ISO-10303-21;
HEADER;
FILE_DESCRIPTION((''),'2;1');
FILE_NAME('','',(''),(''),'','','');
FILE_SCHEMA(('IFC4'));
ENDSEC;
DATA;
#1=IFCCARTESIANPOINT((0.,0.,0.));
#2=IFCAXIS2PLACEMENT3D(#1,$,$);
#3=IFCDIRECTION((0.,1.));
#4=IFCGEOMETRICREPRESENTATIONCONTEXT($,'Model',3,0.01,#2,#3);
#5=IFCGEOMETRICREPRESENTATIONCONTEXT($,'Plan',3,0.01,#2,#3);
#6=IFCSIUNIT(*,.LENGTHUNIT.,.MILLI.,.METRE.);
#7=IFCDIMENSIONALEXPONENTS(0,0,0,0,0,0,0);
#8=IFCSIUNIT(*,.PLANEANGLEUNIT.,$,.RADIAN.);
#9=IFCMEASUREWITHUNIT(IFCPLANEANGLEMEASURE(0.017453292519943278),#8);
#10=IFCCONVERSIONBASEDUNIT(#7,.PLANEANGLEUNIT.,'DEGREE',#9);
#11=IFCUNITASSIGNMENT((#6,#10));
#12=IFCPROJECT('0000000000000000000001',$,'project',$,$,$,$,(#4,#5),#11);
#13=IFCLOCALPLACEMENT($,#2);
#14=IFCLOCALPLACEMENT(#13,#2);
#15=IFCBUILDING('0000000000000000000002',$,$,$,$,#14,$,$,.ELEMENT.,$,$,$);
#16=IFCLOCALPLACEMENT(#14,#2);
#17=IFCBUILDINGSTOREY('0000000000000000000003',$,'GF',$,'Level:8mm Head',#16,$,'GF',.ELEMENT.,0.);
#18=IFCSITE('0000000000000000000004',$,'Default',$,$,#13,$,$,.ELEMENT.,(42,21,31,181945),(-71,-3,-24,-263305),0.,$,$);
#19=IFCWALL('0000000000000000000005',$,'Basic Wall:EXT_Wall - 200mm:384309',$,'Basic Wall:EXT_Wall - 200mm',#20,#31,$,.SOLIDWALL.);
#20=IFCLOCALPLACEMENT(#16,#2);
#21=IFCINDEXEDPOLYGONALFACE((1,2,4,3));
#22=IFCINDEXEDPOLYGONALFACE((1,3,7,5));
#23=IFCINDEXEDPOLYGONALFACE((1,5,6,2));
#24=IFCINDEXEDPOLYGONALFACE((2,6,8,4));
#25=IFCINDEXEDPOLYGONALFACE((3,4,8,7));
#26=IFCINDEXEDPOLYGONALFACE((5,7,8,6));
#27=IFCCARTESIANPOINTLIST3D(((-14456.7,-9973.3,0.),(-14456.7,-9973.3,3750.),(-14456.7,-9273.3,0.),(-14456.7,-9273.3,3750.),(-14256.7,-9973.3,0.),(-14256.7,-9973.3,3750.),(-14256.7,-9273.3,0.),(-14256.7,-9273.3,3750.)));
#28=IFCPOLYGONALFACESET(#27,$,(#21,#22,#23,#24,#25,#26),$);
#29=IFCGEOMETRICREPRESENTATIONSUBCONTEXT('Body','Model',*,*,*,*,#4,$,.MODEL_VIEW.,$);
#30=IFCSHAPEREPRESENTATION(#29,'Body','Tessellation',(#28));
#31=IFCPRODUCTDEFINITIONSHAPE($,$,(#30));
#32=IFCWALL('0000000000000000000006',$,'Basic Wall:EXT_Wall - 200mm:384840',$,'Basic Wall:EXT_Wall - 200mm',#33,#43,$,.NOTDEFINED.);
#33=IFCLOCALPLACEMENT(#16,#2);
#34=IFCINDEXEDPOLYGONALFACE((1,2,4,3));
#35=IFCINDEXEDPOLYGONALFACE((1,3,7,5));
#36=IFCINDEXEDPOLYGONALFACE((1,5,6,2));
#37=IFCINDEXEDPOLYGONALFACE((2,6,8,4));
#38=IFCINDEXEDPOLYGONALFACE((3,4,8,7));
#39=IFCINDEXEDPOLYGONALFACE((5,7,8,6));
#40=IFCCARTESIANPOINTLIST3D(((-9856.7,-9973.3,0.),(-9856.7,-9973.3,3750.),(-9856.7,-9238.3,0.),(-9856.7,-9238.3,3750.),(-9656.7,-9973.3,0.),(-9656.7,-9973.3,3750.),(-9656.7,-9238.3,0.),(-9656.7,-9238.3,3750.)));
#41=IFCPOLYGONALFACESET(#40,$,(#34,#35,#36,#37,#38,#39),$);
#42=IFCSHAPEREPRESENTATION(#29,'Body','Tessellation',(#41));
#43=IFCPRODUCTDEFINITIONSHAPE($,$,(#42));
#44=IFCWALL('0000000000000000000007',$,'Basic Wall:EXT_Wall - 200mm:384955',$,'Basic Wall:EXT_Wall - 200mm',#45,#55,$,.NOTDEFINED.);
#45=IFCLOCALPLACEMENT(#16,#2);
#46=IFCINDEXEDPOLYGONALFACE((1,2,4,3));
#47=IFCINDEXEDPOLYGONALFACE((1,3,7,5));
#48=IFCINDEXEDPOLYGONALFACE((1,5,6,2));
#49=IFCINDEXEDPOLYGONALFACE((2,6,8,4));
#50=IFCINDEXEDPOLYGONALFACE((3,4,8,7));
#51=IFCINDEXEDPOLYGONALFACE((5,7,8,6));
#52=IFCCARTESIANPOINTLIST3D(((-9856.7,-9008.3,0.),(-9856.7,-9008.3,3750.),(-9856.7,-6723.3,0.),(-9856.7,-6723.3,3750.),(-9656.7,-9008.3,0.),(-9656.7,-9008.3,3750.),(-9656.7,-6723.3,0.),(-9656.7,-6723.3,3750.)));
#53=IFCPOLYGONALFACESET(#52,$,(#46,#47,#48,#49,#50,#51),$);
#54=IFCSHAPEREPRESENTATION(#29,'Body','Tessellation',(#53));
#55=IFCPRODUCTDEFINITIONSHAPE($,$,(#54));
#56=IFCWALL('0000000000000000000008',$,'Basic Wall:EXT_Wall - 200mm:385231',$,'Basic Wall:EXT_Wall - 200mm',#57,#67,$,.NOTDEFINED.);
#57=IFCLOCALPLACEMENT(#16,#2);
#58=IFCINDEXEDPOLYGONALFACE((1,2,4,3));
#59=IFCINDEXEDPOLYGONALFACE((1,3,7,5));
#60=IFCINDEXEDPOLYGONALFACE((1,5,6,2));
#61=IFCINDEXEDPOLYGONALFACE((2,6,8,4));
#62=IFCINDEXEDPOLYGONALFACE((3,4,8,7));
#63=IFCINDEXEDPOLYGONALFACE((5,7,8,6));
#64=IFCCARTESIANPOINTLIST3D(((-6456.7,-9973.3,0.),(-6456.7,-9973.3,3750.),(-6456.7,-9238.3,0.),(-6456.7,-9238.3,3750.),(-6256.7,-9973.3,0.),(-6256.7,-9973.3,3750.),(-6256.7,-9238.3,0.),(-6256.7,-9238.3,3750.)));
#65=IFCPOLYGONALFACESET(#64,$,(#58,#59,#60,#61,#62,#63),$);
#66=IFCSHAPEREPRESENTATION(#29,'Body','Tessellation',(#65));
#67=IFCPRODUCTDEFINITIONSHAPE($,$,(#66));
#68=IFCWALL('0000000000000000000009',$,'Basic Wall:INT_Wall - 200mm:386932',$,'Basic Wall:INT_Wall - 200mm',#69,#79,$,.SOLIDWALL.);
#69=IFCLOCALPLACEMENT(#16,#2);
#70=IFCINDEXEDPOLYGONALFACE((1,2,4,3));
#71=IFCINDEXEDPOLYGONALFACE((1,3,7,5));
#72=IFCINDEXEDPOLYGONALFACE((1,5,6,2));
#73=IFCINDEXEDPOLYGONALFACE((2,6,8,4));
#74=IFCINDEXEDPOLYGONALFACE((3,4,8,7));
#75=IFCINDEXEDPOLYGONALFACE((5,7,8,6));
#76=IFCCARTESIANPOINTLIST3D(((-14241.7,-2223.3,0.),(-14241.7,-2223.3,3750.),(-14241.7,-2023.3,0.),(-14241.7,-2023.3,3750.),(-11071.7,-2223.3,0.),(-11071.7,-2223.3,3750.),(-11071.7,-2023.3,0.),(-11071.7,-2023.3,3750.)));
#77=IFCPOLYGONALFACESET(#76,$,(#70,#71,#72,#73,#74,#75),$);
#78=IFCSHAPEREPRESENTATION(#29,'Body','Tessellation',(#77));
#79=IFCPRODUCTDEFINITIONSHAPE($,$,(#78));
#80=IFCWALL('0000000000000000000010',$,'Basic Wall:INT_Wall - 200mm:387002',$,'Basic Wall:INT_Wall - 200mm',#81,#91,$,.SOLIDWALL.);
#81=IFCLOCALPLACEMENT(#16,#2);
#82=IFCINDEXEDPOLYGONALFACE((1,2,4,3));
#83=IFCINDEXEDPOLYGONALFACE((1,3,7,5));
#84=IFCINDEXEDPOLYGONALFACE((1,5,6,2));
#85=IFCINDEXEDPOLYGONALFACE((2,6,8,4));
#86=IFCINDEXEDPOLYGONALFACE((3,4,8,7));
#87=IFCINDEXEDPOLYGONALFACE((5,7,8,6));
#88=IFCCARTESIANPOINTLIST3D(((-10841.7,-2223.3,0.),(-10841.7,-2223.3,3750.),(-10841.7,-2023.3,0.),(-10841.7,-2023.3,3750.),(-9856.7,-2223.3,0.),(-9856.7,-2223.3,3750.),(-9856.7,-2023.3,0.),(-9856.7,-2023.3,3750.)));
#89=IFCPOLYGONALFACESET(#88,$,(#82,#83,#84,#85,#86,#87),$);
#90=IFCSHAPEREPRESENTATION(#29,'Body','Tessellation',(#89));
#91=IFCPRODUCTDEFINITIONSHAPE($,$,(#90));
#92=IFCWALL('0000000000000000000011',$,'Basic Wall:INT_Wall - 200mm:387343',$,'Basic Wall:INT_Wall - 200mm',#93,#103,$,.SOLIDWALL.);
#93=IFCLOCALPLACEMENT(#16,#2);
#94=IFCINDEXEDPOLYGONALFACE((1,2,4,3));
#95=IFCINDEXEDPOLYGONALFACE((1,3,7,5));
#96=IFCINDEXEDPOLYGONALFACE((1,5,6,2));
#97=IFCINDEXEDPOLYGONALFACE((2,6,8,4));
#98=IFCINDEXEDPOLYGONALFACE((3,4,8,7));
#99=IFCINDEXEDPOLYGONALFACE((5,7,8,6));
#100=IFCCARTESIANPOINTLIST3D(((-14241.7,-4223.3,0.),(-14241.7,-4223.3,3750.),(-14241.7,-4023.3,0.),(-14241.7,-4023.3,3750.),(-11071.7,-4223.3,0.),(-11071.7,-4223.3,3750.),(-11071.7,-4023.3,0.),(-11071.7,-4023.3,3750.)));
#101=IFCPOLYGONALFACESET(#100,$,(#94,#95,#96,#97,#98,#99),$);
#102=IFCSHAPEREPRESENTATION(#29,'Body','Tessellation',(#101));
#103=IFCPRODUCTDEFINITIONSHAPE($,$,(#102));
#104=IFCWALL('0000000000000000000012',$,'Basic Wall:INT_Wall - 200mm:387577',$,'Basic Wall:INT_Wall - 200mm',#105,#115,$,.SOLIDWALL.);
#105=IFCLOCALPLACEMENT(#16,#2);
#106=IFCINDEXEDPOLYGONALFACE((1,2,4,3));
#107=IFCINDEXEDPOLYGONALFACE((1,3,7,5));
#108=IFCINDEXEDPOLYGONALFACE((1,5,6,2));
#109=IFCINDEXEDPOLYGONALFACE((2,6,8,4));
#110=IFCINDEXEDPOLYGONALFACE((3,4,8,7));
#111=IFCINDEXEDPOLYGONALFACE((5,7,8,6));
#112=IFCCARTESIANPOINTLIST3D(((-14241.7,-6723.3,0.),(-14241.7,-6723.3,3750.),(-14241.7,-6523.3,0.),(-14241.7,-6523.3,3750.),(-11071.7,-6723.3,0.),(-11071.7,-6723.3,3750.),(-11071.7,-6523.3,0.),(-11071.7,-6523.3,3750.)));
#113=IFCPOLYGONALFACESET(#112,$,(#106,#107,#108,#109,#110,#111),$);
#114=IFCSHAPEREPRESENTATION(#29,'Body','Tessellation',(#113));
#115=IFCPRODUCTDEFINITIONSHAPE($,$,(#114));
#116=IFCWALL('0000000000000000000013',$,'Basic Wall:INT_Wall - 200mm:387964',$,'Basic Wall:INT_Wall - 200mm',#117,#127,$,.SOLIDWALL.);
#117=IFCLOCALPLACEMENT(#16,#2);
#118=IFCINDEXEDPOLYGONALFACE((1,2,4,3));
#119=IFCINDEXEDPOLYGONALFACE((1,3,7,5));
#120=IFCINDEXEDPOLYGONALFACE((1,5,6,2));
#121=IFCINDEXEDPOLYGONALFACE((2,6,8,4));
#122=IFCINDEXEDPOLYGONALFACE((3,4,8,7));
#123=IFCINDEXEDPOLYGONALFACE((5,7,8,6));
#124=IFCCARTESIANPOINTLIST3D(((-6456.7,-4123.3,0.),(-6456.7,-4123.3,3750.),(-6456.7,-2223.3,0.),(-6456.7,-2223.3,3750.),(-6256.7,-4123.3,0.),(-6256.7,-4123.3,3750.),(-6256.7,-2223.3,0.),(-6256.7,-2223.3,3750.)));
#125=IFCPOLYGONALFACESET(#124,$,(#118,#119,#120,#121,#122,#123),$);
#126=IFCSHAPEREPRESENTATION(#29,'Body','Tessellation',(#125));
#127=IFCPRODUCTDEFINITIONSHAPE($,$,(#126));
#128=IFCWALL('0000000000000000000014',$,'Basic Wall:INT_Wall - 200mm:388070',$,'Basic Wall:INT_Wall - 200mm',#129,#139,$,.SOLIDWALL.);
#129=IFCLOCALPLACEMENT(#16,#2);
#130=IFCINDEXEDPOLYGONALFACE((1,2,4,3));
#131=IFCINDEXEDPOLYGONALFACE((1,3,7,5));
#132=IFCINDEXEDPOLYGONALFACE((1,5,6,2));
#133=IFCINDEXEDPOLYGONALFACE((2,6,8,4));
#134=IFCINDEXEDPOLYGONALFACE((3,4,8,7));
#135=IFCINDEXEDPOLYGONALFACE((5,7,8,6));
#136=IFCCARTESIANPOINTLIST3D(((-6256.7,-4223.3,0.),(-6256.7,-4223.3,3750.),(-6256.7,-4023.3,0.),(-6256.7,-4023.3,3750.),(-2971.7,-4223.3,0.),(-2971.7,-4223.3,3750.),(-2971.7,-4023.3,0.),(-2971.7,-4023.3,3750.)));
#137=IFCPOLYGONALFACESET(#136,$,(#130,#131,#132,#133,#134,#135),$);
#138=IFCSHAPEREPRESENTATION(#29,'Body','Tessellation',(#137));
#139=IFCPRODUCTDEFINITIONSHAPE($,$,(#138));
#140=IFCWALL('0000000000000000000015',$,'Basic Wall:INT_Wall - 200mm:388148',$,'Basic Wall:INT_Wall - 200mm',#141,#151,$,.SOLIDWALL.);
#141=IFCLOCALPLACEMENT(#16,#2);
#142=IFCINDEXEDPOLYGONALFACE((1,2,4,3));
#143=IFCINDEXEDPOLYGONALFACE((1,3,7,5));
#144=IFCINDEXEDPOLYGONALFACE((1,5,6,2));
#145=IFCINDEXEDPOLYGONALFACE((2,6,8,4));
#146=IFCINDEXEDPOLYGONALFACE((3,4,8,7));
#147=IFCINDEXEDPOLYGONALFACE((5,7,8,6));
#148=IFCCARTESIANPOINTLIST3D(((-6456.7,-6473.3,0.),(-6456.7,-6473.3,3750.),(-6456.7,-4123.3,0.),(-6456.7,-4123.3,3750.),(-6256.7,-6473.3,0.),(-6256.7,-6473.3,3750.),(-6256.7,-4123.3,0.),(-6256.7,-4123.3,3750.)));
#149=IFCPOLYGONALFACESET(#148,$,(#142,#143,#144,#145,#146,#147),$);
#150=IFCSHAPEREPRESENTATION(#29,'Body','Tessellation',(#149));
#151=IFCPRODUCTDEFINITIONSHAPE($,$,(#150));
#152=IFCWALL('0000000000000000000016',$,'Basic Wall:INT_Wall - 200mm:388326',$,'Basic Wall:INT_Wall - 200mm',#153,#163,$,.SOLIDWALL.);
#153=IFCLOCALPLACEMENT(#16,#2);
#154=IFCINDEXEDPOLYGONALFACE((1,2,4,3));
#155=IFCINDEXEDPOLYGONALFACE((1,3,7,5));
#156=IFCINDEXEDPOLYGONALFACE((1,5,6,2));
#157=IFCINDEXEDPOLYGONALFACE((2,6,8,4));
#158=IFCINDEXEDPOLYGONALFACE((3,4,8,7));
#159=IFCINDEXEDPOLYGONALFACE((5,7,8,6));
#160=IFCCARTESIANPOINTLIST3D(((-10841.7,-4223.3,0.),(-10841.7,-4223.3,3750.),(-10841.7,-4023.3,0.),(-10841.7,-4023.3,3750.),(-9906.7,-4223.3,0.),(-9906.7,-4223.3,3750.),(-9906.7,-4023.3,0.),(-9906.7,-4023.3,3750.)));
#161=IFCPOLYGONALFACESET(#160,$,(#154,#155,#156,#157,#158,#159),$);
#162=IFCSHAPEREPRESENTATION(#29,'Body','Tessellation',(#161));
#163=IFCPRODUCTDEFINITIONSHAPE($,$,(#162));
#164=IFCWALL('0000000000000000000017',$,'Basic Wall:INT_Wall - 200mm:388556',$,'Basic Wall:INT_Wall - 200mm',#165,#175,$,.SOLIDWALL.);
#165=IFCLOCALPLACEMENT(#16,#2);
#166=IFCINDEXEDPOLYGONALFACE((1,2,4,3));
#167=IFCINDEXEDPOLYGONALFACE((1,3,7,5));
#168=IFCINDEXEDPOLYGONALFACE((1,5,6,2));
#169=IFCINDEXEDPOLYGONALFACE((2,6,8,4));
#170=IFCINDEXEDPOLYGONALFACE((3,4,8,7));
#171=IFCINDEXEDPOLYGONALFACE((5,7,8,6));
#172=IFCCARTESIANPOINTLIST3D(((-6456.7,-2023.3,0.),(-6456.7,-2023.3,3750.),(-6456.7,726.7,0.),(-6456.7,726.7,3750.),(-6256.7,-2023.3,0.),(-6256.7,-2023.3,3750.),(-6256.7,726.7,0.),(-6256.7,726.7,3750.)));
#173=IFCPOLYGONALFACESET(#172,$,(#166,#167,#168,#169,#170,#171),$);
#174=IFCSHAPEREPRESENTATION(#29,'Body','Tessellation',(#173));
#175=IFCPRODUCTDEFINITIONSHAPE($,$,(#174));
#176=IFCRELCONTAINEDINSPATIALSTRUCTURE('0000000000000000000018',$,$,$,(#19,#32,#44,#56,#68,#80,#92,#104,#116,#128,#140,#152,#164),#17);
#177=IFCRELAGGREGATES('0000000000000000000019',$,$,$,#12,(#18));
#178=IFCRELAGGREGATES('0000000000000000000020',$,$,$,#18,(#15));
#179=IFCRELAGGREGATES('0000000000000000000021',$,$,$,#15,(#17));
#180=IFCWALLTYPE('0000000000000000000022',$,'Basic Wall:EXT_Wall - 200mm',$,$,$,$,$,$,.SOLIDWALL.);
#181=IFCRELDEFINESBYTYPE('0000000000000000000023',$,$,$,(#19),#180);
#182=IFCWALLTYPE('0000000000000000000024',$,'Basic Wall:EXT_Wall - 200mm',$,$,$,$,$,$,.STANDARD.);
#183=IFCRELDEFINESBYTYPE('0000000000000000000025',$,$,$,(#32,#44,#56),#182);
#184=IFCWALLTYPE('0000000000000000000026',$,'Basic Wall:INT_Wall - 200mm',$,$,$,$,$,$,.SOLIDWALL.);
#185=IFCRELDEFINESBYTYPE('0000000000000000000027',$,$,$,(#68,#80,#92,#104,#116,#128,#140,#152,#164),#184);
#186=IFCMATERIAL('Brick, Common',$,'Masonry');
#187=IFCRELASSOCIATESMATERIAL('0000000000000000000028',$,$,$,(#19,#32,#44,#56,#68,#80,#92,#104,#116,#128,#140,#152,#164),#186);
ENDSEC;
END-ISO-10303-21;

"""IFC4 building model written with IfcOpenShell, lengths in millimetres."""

from ifc_helpers import new_model, entity, si_unit, converted_unit, direction, frame, origin, place, context, subcontext, project, spatial, indexed_curve, outline, extrude, material, type_object, element, save


model = new_model("IFC4")

# Units and contexts
model_context = context("Model", 3, precision=0.01, world=origin(), true_north=direction((0.0, 1.0)))
plan_context = context("Plan", 3, precision=0.01, world=origin(), true_north=direction((0.0, 1.0)))
body_context = subcontext(model_context, "Body", "Model", "MODEL_VIEW")
ifc_project = project(units=[si_unit("LENGTHUNIT", "METRE", prefix="MILLI"), converted_unit("PLANEANGLEUNIT", "DEGREE", entity("IfcPlaneAngleMeasure", 0.017453292519943278), si_unit("PLANEANGLEUNIT", "RADIAN"), dimensions=[0, 0, 0, 0, 0, 0, 0])], contexts=[model_context, plan_context])

# Site, building, storey
site_placement = place(None, origin())
site = spatial("IfcSite", under=ifc_project, at=site_placement, Name="Default", CompositionType="ELEMENT", RefLatitude=(42, 21, 31, 181945), RefLongitude=(-71, -3, -24, -263305), RefElevation=0.0)
building_placement = place(site_placement, origin())
building = spatial("IfcBuilding", under=site, at=building_placement, CompositionType="ELEMENT")
storey_placement = place(building_placement, origin())
storey = spatial("IfcBuildingStorey", under=building, at=storey_placement, Name="GF", ObjectType="Level:8mm Head", LongName="GF", CompositionType="ELEMENT", Elevation=0.0)

# Walls
ifc_material_1 = material(Name="Brick, Common", Category="Masonry")
wall_type_1 = type_object("IfcWallType", Name="Basic Wall:EXT_Wall - 200mm", PredefinedType="SOLIDWALL")
wall_1_placement = place(storey_placement, frame((-14356.7, -9973.3, 0.0), z_axis=(0.0, 0.0, 1.0), x_axis=(0.0, 1.0, 0.0)))
element("IfcWall", 1, at=wall_1_placement, inside=storey, type_object=wall_type_1, material=ifc_material_1, Name="Basic Wall:EXT_Wall - 200mm:384309", ObjectType="Basic Wall:EXT_Wall - 200mm", PredefinedType="SOLIDWALL", context=body_context, shape_type="SweptSolid", body=[
    extrude(outline(indexed_curve([(700.0, 100.0), (0.0, 100.0), (0.0, -100.0), (700.0, -100.0), (700.0, 100.0)], self_intersect=False)), origin(), (0.0, 0.0, 1.0), 3750.0),
])
wall_type_2 = type_object("IfcWallType", Name="Basic Wall:EXT_Wall - 200mm", PredefinedType="STANDARD")
wall_2_placement = place(storey_placement, frame((-9756.7, -9973.3, 0.0), z_axis=(0.0, 0.0, 1.0), x_axis=(0.0, 1.0, 0.0)))
element("IfcWall", 2, at=wall_2_placement, inside=storey, type_object=wall_type_2, material=ifc_material_1, Name="Basic Wall:EXT_Wall - 200mm:384840", ObjectType="Basic Wall:EXT_Wall - 200mm", PredefinedType="NOTDEFINED", context=body_context, shape_type="SweptSolid", body=[
    extrude(outline(indexed_curve([(735.0, 100.0), (0.0, 100.0), (0.0, -100.0), (735.0, -100.0), (735.0, 100.0)], self_intersect=False)), origin(), (0.0, 0.0, 1.0), 3750.0),
])
wall_3_placement = place(storey_placement, frame((-9756.7, -9008.3, 0.0), z_axis=(0.0, 0.0, 1.0), x_axis=(0.0, 1.0, 0.0)))
element("IfcWall", 3, at=wall_3_placement, inside=storey, type_object=wall_type_2, material=ifc_material_1, Name="Basic Wall:EXT_Wall - 200mm:384955", ObjectType="Basic Wall:EXT_Wall - 200mm", PredefinedType="NOTDEFINED", context=body_context, shape_type="SweptSolid", body=[
    extrude(outline(indexed_curve([(2285.0, 100.0), (0.0, 100.0), (0.0, -100.0), (2285.0, -100.0), (2285.0, 100.0)], self_intersect=False)), origin(), (0.0, 0.0, 1.0), 3750.0),
])
wall_4_placement = place(storey_placement, frame((-6356.7, -9238.3, 0.0), z_axis=(0.0, 0.0, 1.0), x_axis=(0.0, -1.0, 0.0)))
element("IfcWall", 4, at=wall_4_placement, inside=storey, type_object=wall_type_2, material=ifc_material_1, Name="Basic Wall:EXT_Wall - 200mm:385231", ObjectType="Basic Wall:EXT_Wall - 200mm", PredefinedType="NOTDEFINED", context=body_context, shape_type="SweptSolid", body=[
    extrude(outline(indexed_curve([(735.0, 100.0), (0.0, 100.0), (0.0, -100.0), (735.0, -100.0), (735.0, 100.0)], self_intersect=False)), origin(), (0.0, 0.0, 1.0), 3750.0),
])
wall_type_3 = type_object("IfcWallType", Name="Basic Wall:INT_Wall - 200mm", PredefinedType="SOLIDWALL")
wall_5_placement = place(storey_placement, frame((-14241.7, -2123.3, 0.0)))
element("IfcWall", 5, at=wall_5_placement, inside=storey, type_object=wall_type_3, material=ifc_material_1, Name="Basic Wall:INT_Wall - 200mm:386932", ObjectType="Basic Wall:INT_Wall - 200mm", PredefinedType="SOLIDWALL", context=body_context, shape_type="SweptSolid", body=[
    extrude(outline(indexed_curve([(3170.0, 100.0), (0.0, 100.0), (0.0, -100.0), (3170.0, -100.0), (3170.0, 100.0)], self_intersect=False)), origin(), (0.0, 0.0, 1.0), 3750.0),
])
wall_6_placement = place(storey_placement, frame((-10841.7, -2123.3, 0.0)))
element("IfcWall", 6, at=wall_6_placement, inside=storey, type_object=wall_type_3, material=ifc_material_1, Name="Basic Wall:INT_Wall - 200mm:387002", ObjectType="Basic Wall:INT_Wall - 200mm", PredefinedType="SOLIDWALL", context=body_context, shape_type="SweptSolid", body=[
    extrude(outline(indexed_curve([(985.0, 100.0), (0.0, 100.0), (0.0, -100.0), (985.0, -100.0), (985.0, 100.0)], self_intersect=False)), origin(), (0.0, 0.0, 1.0), 3750.0),
])
wall_7_placement = place(storey_placement, frame((-14241.7, -4123.3, 0.0)))
element("IfcWall", 7, at=wall_7_placement, inside=storey, type_object=wall_type_3, material=ifc_material_1, Name="Basic Wall:INT_Wall - 200mm:387343", ObjectType="Basic Wall:INT_Wall - 200mm", PredefinedType="SOLIDWALL", context=body_context, shape_type="SweptSolid", body=[
    extrude(outline(indexed_curve([(3170.0, 100.0), (0.0, 100.0), (0.0, -100.0), (3170.0, -100.0), (3170.0, 100.0)], self_intersect=False)), origin(), (0.0, 0.0, 1.0), 3750.0),
])
wall_8_placement = place(storey_placement, frame((-14241.7, -6623.3, 0.0)))
element("IfcWall", 8, at=wall_8_placement, inside=storey, type_object=wall_type_3, material=ifc_material_1, Name="Basic Wall:INT_Wall - 200mm:387577", ObjectType="Basic Wall:INT_Wall - 200mm", PredefinedType="SOLIDWALL", context=body_context, shape_type="SweptSolid", body=[
    extrude(outline(indexed_curve([(3170.0, 100.0), (0.0, 100.0), (0.0, -100.0), (3170.0, -100.0), (3170.0, 100.0)], self_intersect=False)), origin(), (0.0, 0.0, 1.0), 3750.0),
])
wall_9_placement = place(storey_placement, frame((-6356.7, -2223.3, 0.0), z_axis=(0.0, 0.0, 1.0), x_axis=(0.0, -1.0, 0.0)))
element("IfcWall", 9, at=wall_9_placement, inside=storey, type_object=wall_type_3, material=ifc_material_1, Name="Basic Wall:INT_Wall - 200mm:387964", ObjectType="Basic Wall:INT_Wall - 200mm", PredefinedType="SOLIDWALL", context=body_context, shape_type="SweptSolid", body=[
    extrude(outline(indexed_curve([(1900.0, 100.0), (0.0, 100.0), (0.0, -100.0), (1900.0, -100.0), (1900.0, 100.0)], self_intersect=False)), origin(), (0.0, 0.0, 1.0), 3750.0),
])
wall_10_placement = place(storey_placement, frame((-6256.7, -4123.3, 0.0)))
element("IfcWall", 10, at=wall_10_placement, inside=storey, type_object=wall_type_3, material=ifc_material_1, Name="Basic Wall:INT_Wall - 200mm:388070", ObjectType="Basic Wall:INT_Wall - 200mm", PredefinedType="SOLIDWALL", context=body_context, shape_type="SweptSolid", body=[
    extrude(outline(indexed_curve([(3285.0, 100.0), (0.0, 100.0), (0.0, -100.0), (3285.0, -100.0), (3285.0, 100.0)], self_intersect=False)), origin(), (0.0, 0.0, 1.0), 3750.0),
])
wall_11_placement = place(storey_placement, frame((-6356.7, -6473.3, 0.0), z_axis=(0.0, 0.0, 1.0), x_axis=(0.0, 1.0, 0.0)))
element("IfcWall", 11, at=wall_11_placement, inside=storey, type_object=wall_type_3, material=ifc_material_1, Name="Basic Wall:INT_Wall - 200mm:388148", ObjectType="Basic Wall:INT_Wall - 200mm", PredefinedType="SOLIDWALL", context=body_context, shape_type="SweptSolid", body=[
    extrude(outline(indexed_curve([(2350.0, 100.0), (0.0, 100.0), (0.0, -100.0), (2350.0, -100.0), (2350.0, 100.0)], self_intersect=False)), origin(), (0.0, 0.0, 1.0), 3750.0),
])
wall_12_placement = place(storey_placement, frame((-10841.7, -4123.3, 0.0)))
element("IfcWall", 12, at=wall_12_placement, inside=storey, type_object=wall_type_3, material=ifc_material_1, Name="Basic Wall:INT_Wall - 200mm:388326", ObjectType="Basic Wall:INT_Wall - 200mm", PredefinedType="SOLIDWALL", context=body_context, shape_type="SweptSolid", body=[
    extrude(outline(indexed_curve([(935.0, 100.0), (0.0, 100.0), (0.0, -100.0), (935.0, -100.0), (935.0, 100.0)], self_intersect=False)), origin(), (0.0, 0.0, 1.0), 3750.0),
])
wall_13_placement = place(storey_placement, frame((-6356.7, -2023.3, 0.0), z_axis=(0.0, 0.0, 1.0), x_axis=(0.0, 1.0, 0.0)))
element("IfcWall", 13, at=wall_13_placement, inside=storey, type_object=wall_type_3, material=ifc_material_1, Name="Basic Wall:INT_Wall - 200mm:388556", ObjectType="Basic Wall:INT_Wall - 200mm", PredefinedType="SOLIDWALL", context=body_context, shape_type="SweptSolid", body=[
    extrude(outline(indexed_curve([(2750.0, 100.0), (0.0, 100.0), (0.0, -100.0), (2750.0, -100.0), (2750.0, 100.0)], self_intersect=False)), origin(), (0.0, 0.0, 1.0), 3750.0),
])

save(model, "model.ifc")
